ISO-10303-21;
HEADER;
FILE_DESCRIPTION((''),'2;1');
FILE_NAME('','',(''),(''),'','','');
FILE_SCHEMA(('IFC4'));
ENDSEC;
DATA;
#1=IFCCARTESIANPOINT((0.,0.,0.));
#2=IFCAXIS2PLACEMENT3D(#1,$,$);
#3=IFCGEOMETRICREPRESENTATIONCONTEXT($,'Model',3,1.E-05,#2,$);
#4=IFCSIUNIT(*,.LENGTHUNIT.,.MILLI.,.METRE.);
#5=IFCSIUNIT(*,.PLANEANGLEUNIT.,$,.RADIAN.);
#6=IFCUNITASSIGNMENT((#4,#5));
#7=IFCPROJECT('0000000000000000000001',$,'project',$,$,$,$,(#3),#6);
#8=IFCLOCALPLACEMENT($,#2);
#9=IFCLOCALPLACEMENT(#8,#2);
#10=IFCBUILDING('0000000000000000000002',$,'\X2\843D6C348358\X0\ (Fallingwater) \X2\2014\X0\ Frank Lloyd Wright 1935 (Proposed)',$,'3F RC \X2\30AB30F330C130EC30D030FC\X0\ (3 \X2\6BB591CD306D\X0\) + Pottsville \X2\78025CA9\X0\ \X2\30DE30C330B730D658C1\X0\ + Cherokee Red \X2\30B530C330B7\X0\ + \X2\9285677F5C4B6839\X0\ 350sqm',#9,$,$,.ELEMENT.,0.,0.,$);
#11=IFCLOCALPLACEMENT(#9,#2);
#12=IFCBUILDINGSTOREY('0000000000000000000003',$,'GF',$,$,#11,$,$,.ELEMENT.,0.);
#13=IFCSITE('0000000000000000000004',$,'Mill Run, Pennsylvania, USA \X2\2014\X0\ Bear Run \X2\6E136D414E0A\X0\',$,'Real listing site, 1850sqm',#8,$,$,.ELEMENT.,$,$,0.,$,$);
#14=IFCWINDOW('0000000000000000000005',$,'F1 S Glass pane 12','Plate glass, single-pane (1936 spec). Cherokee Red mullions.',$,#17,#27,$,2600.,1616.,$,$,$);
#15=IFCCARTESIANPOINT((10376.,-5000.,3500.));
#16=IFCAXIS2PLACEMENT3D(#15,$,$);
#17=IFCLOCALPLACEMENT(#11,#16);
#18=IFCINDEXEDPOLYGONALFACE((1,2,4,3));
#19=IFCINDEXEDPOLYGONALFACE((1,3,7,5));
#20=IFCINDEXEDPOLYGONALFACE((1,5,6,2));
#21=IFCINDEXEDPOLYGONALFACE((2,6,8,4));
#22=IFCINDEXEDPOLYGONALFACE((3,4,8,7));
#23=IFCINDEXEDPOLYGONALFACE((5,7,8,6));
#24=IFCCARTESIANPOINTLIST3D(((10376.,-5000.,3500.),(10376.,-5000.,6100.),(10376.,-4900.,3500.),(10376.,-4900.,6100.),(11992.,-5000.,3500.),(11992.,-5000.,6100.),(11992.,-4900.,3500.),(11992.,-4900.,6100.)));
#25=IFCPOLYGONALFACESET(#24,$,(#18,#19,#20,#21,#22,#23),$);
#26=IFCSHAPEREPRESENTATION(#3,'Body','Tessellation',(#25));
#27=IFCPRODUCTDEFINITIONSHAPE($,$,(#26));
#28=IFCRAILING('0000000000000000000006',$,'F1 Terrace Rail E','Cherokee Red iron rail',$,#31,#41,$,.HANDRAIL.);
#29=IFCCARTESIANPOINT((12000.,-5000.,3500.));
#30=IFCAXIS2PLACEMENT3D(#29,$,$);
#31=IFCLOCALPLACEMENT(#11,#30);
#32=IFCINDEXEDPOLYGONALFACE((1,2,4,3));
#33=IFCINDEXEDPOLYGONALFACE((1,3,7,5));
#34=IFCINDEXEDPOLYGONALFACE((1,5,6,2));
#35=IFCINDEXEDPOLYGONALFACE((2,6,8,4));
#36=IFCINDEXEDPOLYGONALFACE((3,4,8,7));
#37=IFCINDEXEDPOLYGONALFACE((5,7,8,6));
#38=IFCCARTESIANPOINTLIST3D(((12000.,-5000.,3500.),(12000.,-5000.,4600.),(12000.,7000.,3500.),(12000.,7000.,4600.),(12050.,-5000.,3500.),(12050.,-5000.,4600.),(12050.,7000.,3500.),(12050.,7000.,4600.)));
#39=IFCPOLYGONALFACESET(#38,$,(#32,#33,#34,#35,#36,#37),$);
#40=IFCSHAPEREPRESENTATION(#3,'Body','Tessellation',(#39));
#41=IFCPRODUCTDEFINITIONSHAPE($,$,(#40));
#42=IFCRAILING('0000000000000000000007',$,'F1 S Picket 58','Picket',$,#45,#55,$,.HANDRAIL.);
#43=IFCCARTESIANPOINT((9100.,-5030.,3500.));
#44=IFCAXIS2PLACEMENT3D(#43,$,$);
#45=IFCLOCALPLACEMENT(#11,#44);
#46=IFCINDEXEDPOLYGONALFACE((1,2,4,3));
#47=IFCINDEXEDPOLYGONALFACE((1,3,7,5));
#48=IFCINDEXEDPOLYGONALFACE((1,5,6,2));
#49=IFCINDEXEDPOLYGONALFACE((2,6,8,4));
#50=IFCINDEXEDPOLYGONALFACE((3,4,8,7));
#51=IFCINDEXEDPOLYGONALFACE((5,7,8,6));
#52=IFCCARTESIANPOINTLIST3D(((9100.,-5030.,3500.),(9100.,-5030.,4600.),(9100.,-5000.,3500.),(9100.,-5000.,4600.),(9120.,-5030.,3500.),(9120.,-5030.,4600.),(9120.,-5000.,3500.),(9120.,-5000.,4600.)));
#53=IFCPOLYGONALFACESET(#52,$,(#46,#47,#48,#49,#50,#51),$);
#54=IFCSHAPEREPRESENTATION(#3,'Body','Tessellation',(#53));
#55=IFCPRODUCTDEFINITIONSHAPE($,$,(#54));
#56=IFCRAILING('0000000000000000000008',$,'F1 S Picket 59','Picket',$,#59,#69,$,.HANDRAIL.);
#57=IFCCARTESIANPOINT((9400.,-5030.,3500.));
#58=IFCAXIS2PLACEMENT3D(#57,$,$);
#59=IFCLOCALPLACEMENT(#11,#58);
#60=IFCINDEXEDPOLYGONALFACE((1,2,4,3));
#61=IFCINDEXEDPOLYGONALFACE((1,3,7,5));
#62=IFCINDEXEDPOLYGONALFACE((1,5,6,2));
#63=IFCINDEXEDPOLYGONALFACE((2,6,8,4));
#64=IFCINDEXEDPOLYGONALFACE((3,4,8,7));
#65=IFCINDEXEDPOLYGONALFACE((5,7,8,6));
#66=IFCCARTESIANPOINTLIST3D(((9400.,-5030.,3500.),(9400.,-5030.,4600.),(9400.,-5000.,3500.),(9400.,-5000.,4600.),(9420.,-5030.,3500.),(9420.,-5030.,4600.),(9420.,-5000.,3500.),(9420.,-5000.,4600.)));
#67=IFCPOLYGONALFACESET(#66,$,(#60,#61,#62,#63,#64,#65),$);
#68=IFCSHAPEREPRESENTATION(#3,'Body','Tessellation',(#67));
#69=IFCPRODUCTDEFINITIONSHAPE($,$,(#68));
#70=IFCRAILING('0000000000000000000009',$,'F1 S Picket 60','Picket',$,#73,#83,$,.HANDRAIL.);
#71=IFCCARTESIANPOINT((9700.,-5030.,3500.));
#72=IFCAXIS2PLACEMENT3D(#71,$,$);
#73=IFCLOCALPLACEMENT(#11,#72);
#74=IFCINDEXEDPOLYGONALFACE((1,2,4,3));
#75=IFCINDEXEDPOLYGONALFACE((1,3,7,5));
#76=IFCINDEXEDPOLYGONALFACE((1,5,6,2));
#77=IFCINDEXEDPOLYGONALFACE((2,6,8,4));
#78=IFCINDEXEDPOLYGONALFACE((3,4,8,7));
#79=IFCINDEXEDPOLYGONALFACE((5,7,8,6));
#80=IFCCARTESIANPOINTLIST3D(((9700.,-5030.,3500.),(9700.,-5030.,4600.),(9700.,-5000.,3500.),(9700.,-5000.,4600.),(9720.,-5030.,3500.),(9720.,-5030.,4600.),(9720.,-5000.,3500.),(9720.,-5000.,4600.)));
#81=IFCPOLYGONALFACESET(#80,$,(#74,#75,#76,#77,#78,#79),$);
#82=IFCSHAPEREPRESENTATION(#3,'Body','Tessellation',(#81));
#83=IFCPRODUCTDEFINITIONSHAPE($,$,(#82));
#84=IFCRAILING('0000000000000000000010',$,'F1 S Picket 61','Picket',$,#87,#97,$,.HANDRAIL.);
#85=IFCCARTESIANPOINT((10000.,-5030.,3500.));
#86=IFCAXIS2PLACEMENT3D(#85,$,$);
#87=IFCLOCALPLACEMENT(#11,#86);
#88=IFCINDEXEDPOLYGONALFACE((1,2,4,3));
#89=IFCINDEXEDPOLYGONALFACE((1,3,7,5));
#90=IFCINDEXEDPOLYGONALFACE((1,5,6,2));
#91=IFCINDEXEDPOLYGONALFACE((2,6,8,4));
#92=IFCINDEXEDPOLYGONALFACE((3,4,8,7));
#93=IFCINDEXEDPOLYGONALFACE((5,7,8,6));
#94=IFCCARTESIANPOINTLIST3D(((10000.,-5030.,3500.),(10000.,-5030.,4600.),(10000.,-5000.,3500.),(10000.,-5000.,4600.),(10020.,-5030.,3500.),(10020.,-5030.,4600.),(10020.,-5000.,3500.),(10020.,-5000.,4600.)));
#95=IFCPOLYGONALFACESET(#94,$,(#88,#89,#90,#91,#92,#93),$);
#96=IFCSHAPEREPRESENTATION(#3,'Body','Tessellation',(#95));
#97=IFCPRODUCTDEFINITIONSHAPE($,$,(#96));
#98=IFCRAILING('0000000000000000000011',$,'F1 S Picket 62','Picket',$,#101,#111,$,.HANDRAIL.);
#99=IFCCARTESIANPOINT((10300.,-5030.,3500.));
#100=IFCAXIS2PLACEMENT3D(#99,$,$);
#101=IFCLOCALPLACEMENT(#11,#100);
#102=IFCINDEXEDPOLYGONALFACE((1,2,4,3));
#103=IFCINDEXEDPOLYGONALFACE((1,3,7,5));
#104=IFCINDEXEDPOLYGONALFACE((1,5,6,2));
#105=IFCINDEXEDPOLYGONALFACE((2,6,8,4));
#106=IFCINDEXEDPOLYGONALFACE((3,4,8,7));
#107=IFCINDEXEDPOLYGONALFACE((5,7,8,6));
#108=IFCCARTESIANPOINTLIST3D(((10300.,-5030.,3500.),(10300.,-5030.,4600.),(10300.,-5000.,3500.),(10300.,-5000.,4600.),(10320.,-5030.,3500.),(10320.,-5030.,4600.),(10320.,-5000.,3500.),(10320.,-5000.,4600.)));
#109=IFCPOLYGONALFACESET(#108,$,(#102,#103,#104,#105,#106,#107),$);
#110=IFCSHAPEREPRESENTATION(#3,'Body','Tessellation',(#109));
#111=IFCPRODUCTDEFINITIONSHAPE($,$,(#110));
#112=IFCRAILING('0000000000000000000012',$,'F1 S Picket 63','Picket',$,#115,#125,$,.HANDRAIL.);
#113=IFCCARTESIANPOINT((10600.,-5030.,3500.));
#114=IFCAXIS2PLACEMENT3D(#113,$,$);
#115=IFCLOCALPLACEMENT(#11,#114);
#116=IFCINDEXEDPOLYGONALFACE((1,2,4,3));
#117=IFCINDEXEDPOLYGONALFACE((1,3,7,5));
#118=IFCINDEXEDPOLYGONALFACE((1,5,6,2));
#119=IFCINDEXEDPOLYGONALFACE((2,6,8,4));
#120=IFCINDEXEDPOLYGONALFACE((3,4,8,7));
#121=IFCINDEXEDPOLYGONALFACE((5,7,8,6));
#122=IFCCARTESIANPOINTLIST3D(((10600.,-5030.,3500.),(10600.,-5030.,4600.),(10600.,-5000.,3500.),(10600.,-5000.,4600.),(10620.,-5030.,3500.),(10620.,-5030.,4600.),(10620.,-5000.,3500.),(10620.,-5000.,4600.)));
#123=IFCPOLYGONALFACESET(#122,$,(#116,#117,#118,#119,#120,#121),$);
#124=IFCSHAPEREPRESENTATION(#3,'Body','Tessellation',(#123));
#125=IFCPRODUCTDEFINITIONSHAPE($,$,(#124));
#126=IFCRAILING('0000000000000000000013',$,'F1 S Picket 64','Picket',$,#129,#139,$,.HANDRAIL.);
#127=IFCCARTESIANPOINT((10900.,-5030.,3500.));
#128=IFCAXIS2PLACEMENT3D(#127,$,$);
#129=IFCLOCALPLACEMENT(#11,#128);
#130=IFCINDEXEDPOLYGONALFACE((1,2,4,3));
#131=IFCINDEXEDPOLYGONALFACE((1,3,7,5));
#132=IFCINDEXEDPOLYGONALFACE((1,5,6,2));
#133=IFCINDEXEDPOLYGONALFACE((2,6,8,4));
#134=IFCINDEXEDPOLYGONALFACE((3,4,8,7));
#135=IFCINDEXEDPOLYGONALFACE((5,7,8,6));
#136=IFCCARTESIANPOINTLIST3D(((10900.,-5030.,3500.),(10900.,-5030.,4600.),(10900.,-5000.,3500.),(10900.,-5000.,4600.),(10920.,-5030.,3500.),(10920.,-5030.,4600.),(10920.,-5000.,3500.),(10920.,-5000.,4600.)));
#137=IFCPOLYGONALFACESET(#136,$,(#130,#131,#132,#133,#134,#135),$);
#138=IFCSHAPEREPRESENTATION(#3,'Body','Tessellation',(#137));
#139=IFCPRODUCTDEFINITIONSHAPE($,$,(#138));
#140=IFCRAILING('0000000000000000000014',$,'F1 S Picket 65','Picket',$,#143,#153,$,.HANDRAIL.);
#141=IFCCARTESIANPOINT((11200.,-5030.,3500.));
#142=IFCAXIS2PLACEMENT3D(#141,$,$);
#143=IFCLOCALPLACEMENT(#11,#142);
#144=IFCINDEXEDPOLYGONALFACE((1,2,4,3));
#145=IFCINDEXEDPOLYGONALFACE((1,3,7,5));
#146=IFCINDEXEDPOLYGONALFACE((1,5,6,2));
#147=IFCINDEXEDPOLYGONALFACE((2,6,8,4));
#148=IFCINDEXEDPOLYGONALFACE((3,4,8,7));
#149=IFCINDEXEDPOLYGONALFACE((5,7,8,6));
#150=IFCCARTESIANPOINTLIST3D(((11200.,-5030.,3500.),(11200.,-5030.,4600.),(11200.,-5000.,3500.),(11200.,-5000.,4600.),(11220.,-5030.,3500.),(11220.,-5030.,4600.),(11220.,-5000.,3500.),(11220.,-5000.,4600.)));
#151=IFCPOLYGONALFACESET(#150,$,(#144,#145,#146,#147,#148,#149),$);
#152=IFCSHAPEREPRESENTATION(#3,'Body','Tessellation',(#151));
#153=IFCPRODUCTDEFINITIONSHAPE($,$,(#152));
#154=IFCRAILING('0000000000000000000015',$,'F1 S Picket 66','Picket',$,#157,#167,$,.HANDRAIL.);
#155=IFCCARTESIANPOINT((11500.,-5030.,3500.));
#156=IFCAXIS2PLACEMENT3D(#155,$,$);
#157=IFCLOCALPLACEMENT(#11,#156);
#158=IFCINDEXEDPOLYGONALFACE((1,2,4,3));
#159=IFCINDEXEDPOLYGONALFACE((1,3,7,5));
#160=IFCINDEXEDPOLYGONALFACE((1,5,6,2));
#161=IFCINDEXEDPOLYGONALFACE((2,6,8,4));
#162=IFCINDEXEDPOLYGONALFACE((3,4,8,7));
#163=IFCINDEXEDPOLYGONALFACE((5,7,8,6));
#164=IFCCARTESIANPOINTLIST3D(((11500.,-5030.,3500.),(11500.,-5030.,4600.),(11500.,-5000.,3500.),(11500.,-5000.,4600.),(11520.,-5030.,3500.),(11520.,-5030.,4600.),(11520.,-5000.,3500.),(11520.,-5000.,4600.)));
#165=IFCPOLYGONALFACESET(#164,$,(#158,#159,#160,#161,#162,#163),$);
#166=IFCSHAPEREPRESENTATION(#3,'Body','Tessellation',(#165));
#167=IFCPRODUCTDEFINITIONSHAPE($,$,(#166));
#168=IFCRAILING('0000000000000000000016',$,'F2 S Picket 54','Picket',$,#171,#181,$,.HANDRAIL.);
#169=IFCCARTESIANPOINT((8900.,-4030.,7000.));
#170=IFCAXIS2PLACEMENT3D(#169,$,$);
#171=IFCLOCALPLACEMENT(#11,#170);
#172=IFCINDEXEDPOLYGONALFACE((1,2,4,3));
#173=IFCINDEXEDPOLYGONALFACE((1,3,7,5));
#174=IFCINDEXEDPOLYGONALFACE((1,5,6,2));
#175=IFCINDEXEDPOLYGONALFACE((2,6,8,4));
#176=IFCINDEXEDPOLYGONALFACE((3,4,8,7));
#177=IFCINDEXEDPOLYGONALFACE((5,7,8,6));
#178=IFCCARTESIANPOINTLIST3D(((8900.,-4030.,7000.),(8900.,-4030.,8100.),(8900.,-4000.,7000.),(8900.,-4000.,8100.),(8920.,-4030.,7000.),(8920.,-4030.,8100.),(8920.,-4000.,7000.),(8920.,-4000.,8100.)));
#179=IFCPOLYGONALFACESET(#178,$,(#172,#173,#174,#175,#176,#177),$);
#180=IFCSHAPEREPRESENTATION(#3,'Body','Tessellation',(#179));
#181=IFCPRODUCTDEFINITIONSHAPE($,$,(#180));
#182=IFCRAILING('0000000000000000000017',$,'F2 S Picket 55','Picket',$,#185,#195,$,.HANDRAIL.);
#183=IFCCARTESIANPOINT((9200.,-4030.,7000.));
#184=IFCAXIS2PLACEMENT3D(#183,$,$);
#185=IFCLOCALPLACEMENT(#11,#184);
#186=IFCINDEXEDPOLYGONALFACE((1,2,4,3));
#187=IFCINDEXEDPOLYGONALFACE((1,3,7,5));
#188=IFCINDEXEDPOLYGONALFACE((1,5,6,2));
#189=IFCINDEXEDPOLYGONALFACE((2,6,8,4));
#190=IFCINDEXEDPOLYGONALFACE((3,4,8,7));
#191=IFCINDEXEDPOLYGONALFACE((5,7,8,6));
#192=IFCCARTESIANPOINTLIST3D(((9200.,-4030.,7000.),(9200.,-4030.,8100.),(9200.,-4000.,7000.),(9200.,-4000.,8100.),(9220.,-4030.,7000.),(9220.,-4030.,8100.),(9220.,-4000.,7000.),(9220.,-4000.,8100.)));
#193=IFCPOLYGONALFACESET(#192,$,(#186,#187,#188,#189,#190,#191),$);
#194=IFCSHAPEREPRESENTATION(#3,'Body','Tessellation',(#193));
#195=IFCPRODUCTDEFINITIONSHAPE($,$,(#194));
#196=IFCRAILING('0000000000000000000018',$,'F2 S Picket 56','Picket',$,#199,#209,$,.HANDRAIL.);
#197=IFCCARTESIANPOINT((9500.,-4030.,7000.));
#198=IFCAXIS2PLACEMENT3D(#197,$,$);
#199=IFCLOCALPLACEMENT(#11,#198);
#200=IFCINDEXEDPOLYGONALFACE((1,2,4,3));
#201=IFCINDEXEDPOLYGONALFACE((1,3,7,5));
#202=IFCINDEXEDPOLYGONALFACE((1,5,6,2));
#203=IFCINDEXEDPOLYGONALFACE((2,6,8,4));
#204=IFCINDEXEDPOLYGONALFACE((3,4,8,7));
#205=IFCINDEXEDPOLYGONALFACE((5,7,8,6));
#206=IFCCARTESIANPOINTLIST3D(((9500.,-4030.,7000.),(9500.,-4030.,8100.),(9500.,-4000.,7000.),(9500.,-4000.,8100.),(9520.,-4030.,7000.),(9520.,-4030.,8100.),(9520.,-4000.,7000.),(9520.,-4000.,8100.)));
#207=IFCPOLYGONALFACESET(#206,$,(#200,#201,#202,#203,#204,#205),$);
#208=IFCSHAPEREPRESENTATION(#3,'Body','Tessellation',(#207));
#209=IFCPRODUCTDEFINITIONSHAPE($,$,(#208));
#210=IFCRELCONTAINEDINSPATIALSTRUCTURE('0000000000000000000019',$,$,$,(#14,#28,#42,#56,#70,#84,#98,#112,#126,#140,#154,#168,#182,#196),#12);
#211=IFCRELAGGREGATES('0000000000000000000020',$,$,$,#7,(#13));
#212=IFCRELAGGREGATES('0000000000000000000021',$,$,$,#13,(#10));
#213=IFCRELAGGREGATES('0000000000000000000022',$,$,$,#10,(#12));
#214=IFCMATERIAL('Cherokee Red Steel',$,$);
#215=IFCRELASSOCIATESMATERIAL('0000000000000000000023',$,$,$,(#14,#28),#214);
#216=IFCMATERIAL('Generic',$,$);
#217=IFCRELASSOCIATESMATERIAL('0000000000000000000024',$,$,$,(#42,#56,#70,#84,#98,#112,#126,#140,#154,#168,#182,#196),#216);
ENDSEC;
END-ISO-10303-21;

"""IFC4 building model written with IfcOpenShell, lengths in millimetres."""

from ifc_helpers import new_model, si_unit, frame, frame_2d, origin, place, context, project, spatial, rectangle, extrude, material, element, save


model = new_model("IFC4")

# Units and contexts
model_context = context("Model", 3, precision=1e-05, world=origin())
ifc_project = project(units=[si_unit("LENGTHUNIT", "METRE", prefix="MILLI"), si_unit("PLANEANGLEUNIT", "RADIAN")], contexts=[model_context])

# Site, building, storey
site_placement = place(None, origin())
site = spatial("IfcSite", under=ifc_project, at=site_placement, Name="Mill Run, Pennsylvania, USA — Bear Run 渓流上", ObjectType="Real listing site, 1850sqm", CompositionType="ELEMENT", RefElevation=0.0)
building_placement = place(site_placement, origin())
building = spatial("IfcBuilding", under=site, at=building_placement, Name="落水荘 (Fallingwater) — Frank Lloyd Wright 1935 (Proposed)", ObjectType="3F RC カンチレバー (3 段重ね) + Pottsville 砂岩 マッシブ壁 + Cherokee Red サッシ + 銅板屋根 350sqm", CompositionType="ELEMENT", ElevationOfRefHeight=0.0, ElevationOfTerrain=0.0)
storey_placement = place(building_placement, origin())
storey = spatial("IfcBuildingStorey", under=building, at=storey_placement, Name="GF", CompositionType="ELEMENT", Elevation=0.0)

# Window
ifc_material_1 = material(Name="Cherokee Red Steel")
window_placement = place(storey_placement, frame((10376.0, -5000.0, 3500.0)))
element("IfcWindow", 1, at=window_placement, inside=storey, material=ifc_material_1, Name="F1 S Glass pane 12", Description="Plate glass, single-pane (1936 spec). Cherokee Red mullions.", OverallHeight=2600.0, OverallWidth=1616.0, context=model_context, shape_type="SweptSolid", body=[
    extrude(rectangle(XDim=1616.0, YDim=100.0, at=frame_2d((808.0, 50.0))), frame((10376.0, -5000.0, 3500.0)), (0.0, 0.0, 1.0), 2600.0),
])

# Railings
railing_1_placement = place(storey_placement, frame((12000.0, -5000.0, 3500.0)))
element("IfcRailing", 2, at=railing_1_placement, inside=storey, material=ifc_material_1, Name="F1 Terrace Rail E", Description="Cherokee Red iron rail", PredefinedType="HANDRAIL", context=model_context, shape_type="SweptSolid", body=[
    extrude(rectangle(XDim=50.0, YDim=12000.0, at=frame_2d((25.0, 6000.0))), frame((12000.0, -5000.0, 3500.0)), (0.0, 0.0, 1.0), 1100.0),
])
ifc_material_2 = material(Name="Generic")
railing_2_placement = place(storey_placement, frame((9100.0, -5030.0, 3500.0)))
element("IfcRailing", 3, at=railing_2_placement, inside=storey, material=ifc_material_2, Name="F1 S Picket 58", Description="Picket", PredefinedType="HANDRAIL", context=model_context, shape_type="SweptSolid", body=[
    extrude(rectangle(XDim=20.0, YDim=30.0, at=frame_2d((10.0, 15.0))), frame((9100.0, -5030.0, 3500.0)), (0.0, 0.0, 1.0), 1100.0),
])
railing_3_placement = place(storey_placement, frame((9400.0, -5030.0, 3500.0)))
element("IfcRailing", 4, at=railing_3_placement, inside=storey, material=ifc_material_2, Name="F1 S Picket 59", Description="Picket", PredefinedType="HANDRAIL", context=model_context, shape_type="SweptSolid", body=[
    extrude(rectangle(XDim=20.0, YDim=30.0, at=frame_2d((10.0, 15.0))), frame((9400.0, -5030.0, 3500.0)), (0.0, 0.0, 1.0), 1100.0),
])
railing_4_placement = place(storey_placement, frame((9700.0, -5030.0, 3500.0)))
element("IfcRailing", 5, at=railing_4_placement, inside=storey, material=ifc_material_2, Name="F1 S Picket 60", Description="Picket", PredefinedType="HANDRAIL", context=model_context, shape_type="SweptSolid", body=[
    extrude(rectangle(XDim=20.0, YDim=30.0, at=frame_2d((10.0, 15.0))), frame((9700.0, -5030.0, 3500.0)), (0.0, 0.0, 1.0), 1100.0),
])
railing_5_placement = place(storey_placement, frame((10000.0, -5030.0, 3500.0)))
element("IfcRailing", 6, at=railing_5_placement, inside=storey, material=ifc_material_2, Name="F1 S Picket 61", Description="Picket", PredefinedType="HANDRAIL", context=model_context, shape_type="SweptSolid", body=[
    extrude(rectangle(XDim=20.0, YDim=30.0, at=frame_2d((10.0, 15.0))), frame((10000.0, -5030.0, 3500.0)), (0.0, 0.0, 1.0), 1100.0),
])
railing_6_placement = place(storey_placement, frame((10300.0, -5030.0, 3500.0)))
element("IfcRailing", 7, at=railing_6_placement, inside=storey, material=ifc_material_2, Name="F1 S Picket 62", Description="Picket", PredefinedType="HANDRAIL", context=model_context, shape_type="SweptSolid", body=[
    extrude(rectangle(XDim=20.0, YDim=30.0, at=frame_2d((10.0, 15.0))), frame((10300.0, -5030.0, 3500.0)), (0.0, 0.0, 1.0), 1100.0),
])
railing_7_placement = place(storey_placement, frame((10600.0, -5030.0, 3500.0)))
element("IfcRailing", 8, at=railing_7_placement, inside=storey, material=ifc_material_2, Name="F1 S Picket 63", Description="Picket", PredefinedType="HANDRAIL", context=model_context, shape_type="SweptSolid", body=[
    extrude(rectangle(XDim=20.0, YDim=30.0, at=frame_2d((10.0, 15.0))), frame((10600.0, -5030.0, 3500.0)), (0.0, 0.0, 1.0), 1100.0),
])
railing_8_placement = place(storey_placement, frame((10900.0, -5030.0, 3500.0)))
element("IfcRailing", 9, at=railing_8_placement, inside=storey, material=ifc_material_2, Name="F1 S Picket 64", Description="Picket", PredefinedType="HANDRAIL", context=model_context, shape_type="SweptSolid", body=[
    extrude(rectangle(XDim=20.0, YDim=30.0, at=frame_2d((10.0, 15.0))), frame((10900.0, -5030.0, 3500.0)), (0.0, 0.0, 1.0), 1100.0),
])
railing_9_placement = place(storey_placement, frame((11200.0, -5030.0, 3500.0)))
element("IfcRailing", 10, at=railing_9_placement, inside=storey, material=ifc_material_2, Name="F1 S Picket 65", Description="Picket", PredefinedType="HANDRAIL", context=model_context, shape_type="SweptSolid", body=[
    extrude(rectangle(XDim=20.0, YDim=30.0, at=frame_2d((10.0, 15.0))), frame((11200.0, -5030.0, 3500.0)), (0.0, 0.0, 1.0), 1100.0),
])
railing_10_placement = place(storey_placement, frame((11500.0, -5030.0, 3500.0)))
element("IfcRailing", 11, at=railing_10_placement, inside=storey, material=ifc_material_2, Name="F1 S Picket 66", Description="Picket", PredefinedType="HANDRAIL", context=model_context, shape_type="SweptSolid", body=[
    extrude(rectangle(XDim=20.0, YDim=30.0, at=frame_2d((10.0, 15.0))), frame((11500.0, -5030.0, 3500.0)), (0.0, 0.0, 1.0), 1100.0),
])
railing_11_placement = place(storey_placement, frame((8900.0, -4030.0, 7000.0)))
element("IfcRailing", 12, at=railing_11_placement, inside=storey, material=ifc_material_2, Name="F2 S Picket 54", Description="Picket", PredefinedType="HANDRAIL", context=model_context, shape_type="SweptSolid", body=[
    extrude(rectangle(XDim=20.0, YDim=30.0, at=frame_2d((10.0, 15.0))), frame((8900.0, -4030.0, 7000.0)), (0.0, 0.0, 1.0), 1100.0),
])
railing_12_placement = place(storey_placement, frame((9200.0, -4030.0, 7000.0)))
element("IfcRailing", 13, at=railing_12_placement, inside=storey, material=ifc_material_2, Name="F2 S Picket 55", Description="Picket", PredefinedType="HANDRAIL", context=model_context, shape_type="SweptSolid", body=[
    extrude(rectangle(XDim=20.0, YDim=30.0, at=frame_2d((10.0, 15.0))), frame((9200.0, -4030.0, 7000.0)), (0.0, 0.0, 1.0), 1100.0),
])
railing_13_placement = place(storey_placement, frame((9500.0, -4030.0, 7000.0)))
element("IfcRailing", 14, at=railing_13_placement, inside=storey, material=ifc_material_2, Name="F2 S Picket 56", Description="Picket", PredefinedType="HANDRAIL", context=model_context, shape_type="SweptSolid", body=[
    extrude(rectangle(XDim=20.0, YDim=30.0, at=frame_2d((10.0, 15.0))), frame((9500.0, -4030.0, 7000.0)), (0.0, 0.0, 1.0), 1100.0),
])

save(model, "model.ifc")
